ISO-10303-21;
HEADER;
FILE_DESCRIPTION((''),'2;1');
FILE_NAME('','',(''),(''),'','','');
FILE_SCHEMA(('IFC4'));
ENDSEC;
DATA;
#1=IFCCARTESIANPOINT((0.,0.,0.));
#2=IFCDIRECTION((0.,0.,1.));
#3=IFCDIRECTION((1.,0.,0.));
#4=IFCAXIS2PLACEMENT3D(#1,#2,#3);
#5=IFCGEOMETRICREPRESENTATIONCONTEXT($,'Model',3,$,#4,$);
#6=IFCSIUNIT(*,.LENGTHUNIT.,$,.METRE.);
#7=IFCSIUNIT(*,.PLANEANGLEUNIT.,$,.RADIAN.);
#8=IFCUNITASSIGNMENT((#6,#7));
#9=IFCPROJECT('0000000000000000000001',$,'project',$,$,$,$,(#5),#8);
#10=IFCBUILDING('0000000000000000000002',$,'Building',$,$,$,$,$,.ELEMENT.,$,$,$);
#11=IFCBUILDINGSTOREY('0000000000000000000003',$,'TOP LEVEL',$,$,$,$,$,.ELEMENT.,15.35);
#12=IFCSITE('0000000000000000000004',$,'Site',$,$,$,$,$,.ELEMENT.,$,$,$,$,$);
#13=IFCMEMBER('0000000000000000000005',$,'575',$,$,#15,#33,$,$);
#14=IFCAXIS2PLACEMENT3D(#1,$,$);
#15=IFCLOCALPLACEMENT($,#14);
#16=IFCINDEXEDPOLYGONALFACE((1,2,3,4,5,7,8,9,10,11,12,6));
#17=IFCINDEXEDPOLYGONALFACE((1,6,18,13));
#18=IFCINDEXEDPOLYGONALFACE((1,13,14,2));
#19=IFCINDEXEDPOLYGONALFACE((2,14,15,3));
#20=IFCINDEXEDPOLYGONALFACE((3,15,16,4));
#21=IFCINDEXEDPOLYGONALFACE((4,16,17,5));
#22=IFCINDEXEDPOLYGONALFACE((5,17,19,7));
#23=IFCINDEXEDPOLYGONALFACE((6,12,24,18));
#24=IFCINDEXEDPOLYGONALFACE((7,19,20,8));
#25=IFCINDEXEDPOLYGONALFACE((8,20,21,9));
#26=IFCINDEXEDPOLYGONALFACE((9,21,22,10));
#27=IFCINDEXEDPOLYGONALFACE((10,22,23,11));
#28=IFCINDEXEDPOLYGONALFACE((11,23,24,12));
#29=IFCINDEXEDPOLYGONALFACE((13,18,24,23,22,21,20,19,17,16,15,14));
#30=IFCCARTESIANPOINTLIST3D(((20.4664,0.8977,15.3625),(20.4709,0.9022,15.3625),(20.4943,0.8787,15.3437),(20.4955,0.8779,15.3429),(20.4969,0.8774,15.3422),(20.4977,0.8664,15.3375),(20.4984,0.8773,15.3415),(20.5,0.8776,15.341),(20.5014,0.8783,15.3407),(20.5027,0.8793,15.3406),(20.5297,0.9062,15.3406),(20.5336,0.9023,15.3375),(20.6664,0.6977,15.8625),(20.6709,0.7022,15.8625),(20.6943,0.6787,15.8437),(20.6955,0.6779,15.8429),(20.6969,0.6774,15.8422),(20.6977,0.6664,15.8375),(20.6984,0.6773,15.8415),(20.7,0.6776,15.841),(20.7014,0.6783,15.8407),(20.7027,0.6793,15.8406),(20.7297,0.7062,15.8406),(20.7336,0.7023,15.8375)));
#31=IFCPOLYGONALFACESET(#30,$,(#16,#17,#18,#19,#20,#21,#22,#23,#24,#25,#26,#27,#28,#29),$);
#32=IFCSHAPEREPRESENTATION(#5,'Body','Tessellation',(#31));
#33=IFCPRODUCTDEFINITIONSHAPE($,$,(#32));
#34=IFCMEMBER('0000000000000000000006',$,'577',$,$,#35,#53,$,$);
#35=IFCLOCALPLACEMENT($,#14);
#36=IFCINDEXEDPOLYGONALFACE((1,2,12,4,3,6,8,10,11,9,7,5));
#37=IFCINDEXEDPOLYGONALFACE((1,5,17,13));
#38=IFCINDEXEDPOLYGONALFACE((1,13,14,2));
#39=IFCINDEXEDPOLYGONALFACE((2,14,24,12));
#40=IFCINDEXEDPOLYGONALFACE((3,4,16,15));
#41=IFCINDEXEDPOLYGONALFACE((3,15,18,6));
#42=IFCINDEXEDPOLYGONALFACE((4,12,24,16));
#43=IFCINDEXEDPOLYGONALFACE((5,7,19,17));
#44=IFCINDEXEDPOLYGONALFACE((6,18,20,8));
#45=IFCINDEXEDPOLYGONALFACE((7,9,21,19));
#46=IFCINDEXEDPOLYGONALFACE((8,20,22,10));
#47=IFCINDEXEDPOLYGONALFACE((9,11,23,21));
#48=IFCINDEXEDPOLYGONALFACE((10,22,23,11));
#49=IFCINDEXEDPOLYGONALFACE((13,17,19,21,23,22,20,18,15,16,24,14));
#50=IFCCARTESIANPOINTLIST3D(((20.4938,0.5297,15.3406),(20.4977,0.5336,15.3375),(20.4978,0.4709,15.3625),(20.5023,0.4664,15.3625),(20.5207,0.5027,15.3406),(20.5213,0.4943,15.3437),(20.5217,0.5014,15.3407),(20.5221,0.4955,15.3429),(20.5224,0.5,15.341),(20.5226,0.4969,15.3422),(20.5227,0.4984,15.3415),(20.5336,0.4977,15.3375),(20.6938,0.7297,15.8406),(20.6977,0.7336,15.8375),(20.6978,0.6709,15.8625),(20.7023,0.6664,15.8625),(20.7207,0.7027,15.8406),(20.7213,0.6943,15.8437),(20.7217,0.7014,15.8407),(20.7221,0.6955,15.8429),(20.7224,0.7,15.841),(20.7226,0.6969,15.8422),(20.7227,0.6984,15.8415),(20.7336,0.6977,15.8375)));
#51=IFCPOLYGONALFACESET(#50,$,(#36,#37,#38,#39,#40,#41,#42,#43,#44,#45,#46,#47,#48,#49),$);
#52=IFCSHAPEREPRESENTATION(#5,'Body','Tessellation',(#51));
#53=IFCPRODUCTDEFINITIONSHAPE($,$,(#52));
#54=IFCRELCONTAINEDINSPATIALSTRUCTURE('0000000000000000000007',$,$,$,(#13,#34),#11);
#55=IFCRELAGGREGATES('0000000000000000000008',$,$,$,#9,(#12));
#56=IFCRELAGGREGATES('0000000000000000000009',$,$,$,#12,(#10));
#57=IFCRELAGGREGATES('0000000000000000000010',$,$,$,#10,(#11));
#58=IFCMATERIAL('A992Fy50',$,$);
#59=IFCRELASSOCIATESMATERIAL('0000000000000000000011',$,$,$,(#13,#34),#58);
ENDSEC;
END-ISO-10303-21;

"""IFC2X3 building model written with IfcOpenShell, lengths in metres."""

from ifc_helpers import new_model, si_unit, frame, origin_with_axes, origin_2d_with_axis, place, context, project, spatial, l_section, extrude, material, element, save


model = new_model("IFC2X3")

# Units and contexts
model_context = context("Model", 3, world=origin_with_axes())
ifc_project = project(units=[si_unit("LENGTHUNIT", "METRE"), si_unit("PLANEANGLEUNIT", "RADIAN")], contexts=[model_context])

# Site, building, storey
site = spatial("IfcSite", under=ifc_project, Name="Site", CompositionType="ELEMENT")
building = spatial("IfcBuilding", under=site, Name="Building", CompositionType="ELEMENT")
storey = spatial("IfcBuildingStorey", under=building, Name="TOP LEVEL", CompositionType="ELEMENT", Elevation=15.35)

# Shared definitions
ifc_material = material(Name="A992Fy50")

# Members
for number, where, z_axis, x_axis, name in (
    (1, (20.5, 0.9, 15.35), (0.348155, -0.348155, 0.870388), (0.707107, 0.707107, 0.0), "575"),
    (2, (20.5, 0.5, 15.35), (0.348155, 0.348155, 0.870388), (-0.707107, 0.707107, 0.0), "577"),
):
    element("IfcMember", number, at=place(None, frame(where, z_axis=z_axis, x_axis=x_axis)), inside=storey, material=ifc_material, Name=name, context=model_context, shape_type="SweptSolid", body=[
        extrude(l_section(Depth=0.0508, Width=0.0508, Thickness=0.0063, FilletRadius=0.0063, at=origin_2d_with_axis()), origin_with_axes(), (0.0, 0.0, 1.0), 0.5745),
    ])

save(model, "model.ifc")
